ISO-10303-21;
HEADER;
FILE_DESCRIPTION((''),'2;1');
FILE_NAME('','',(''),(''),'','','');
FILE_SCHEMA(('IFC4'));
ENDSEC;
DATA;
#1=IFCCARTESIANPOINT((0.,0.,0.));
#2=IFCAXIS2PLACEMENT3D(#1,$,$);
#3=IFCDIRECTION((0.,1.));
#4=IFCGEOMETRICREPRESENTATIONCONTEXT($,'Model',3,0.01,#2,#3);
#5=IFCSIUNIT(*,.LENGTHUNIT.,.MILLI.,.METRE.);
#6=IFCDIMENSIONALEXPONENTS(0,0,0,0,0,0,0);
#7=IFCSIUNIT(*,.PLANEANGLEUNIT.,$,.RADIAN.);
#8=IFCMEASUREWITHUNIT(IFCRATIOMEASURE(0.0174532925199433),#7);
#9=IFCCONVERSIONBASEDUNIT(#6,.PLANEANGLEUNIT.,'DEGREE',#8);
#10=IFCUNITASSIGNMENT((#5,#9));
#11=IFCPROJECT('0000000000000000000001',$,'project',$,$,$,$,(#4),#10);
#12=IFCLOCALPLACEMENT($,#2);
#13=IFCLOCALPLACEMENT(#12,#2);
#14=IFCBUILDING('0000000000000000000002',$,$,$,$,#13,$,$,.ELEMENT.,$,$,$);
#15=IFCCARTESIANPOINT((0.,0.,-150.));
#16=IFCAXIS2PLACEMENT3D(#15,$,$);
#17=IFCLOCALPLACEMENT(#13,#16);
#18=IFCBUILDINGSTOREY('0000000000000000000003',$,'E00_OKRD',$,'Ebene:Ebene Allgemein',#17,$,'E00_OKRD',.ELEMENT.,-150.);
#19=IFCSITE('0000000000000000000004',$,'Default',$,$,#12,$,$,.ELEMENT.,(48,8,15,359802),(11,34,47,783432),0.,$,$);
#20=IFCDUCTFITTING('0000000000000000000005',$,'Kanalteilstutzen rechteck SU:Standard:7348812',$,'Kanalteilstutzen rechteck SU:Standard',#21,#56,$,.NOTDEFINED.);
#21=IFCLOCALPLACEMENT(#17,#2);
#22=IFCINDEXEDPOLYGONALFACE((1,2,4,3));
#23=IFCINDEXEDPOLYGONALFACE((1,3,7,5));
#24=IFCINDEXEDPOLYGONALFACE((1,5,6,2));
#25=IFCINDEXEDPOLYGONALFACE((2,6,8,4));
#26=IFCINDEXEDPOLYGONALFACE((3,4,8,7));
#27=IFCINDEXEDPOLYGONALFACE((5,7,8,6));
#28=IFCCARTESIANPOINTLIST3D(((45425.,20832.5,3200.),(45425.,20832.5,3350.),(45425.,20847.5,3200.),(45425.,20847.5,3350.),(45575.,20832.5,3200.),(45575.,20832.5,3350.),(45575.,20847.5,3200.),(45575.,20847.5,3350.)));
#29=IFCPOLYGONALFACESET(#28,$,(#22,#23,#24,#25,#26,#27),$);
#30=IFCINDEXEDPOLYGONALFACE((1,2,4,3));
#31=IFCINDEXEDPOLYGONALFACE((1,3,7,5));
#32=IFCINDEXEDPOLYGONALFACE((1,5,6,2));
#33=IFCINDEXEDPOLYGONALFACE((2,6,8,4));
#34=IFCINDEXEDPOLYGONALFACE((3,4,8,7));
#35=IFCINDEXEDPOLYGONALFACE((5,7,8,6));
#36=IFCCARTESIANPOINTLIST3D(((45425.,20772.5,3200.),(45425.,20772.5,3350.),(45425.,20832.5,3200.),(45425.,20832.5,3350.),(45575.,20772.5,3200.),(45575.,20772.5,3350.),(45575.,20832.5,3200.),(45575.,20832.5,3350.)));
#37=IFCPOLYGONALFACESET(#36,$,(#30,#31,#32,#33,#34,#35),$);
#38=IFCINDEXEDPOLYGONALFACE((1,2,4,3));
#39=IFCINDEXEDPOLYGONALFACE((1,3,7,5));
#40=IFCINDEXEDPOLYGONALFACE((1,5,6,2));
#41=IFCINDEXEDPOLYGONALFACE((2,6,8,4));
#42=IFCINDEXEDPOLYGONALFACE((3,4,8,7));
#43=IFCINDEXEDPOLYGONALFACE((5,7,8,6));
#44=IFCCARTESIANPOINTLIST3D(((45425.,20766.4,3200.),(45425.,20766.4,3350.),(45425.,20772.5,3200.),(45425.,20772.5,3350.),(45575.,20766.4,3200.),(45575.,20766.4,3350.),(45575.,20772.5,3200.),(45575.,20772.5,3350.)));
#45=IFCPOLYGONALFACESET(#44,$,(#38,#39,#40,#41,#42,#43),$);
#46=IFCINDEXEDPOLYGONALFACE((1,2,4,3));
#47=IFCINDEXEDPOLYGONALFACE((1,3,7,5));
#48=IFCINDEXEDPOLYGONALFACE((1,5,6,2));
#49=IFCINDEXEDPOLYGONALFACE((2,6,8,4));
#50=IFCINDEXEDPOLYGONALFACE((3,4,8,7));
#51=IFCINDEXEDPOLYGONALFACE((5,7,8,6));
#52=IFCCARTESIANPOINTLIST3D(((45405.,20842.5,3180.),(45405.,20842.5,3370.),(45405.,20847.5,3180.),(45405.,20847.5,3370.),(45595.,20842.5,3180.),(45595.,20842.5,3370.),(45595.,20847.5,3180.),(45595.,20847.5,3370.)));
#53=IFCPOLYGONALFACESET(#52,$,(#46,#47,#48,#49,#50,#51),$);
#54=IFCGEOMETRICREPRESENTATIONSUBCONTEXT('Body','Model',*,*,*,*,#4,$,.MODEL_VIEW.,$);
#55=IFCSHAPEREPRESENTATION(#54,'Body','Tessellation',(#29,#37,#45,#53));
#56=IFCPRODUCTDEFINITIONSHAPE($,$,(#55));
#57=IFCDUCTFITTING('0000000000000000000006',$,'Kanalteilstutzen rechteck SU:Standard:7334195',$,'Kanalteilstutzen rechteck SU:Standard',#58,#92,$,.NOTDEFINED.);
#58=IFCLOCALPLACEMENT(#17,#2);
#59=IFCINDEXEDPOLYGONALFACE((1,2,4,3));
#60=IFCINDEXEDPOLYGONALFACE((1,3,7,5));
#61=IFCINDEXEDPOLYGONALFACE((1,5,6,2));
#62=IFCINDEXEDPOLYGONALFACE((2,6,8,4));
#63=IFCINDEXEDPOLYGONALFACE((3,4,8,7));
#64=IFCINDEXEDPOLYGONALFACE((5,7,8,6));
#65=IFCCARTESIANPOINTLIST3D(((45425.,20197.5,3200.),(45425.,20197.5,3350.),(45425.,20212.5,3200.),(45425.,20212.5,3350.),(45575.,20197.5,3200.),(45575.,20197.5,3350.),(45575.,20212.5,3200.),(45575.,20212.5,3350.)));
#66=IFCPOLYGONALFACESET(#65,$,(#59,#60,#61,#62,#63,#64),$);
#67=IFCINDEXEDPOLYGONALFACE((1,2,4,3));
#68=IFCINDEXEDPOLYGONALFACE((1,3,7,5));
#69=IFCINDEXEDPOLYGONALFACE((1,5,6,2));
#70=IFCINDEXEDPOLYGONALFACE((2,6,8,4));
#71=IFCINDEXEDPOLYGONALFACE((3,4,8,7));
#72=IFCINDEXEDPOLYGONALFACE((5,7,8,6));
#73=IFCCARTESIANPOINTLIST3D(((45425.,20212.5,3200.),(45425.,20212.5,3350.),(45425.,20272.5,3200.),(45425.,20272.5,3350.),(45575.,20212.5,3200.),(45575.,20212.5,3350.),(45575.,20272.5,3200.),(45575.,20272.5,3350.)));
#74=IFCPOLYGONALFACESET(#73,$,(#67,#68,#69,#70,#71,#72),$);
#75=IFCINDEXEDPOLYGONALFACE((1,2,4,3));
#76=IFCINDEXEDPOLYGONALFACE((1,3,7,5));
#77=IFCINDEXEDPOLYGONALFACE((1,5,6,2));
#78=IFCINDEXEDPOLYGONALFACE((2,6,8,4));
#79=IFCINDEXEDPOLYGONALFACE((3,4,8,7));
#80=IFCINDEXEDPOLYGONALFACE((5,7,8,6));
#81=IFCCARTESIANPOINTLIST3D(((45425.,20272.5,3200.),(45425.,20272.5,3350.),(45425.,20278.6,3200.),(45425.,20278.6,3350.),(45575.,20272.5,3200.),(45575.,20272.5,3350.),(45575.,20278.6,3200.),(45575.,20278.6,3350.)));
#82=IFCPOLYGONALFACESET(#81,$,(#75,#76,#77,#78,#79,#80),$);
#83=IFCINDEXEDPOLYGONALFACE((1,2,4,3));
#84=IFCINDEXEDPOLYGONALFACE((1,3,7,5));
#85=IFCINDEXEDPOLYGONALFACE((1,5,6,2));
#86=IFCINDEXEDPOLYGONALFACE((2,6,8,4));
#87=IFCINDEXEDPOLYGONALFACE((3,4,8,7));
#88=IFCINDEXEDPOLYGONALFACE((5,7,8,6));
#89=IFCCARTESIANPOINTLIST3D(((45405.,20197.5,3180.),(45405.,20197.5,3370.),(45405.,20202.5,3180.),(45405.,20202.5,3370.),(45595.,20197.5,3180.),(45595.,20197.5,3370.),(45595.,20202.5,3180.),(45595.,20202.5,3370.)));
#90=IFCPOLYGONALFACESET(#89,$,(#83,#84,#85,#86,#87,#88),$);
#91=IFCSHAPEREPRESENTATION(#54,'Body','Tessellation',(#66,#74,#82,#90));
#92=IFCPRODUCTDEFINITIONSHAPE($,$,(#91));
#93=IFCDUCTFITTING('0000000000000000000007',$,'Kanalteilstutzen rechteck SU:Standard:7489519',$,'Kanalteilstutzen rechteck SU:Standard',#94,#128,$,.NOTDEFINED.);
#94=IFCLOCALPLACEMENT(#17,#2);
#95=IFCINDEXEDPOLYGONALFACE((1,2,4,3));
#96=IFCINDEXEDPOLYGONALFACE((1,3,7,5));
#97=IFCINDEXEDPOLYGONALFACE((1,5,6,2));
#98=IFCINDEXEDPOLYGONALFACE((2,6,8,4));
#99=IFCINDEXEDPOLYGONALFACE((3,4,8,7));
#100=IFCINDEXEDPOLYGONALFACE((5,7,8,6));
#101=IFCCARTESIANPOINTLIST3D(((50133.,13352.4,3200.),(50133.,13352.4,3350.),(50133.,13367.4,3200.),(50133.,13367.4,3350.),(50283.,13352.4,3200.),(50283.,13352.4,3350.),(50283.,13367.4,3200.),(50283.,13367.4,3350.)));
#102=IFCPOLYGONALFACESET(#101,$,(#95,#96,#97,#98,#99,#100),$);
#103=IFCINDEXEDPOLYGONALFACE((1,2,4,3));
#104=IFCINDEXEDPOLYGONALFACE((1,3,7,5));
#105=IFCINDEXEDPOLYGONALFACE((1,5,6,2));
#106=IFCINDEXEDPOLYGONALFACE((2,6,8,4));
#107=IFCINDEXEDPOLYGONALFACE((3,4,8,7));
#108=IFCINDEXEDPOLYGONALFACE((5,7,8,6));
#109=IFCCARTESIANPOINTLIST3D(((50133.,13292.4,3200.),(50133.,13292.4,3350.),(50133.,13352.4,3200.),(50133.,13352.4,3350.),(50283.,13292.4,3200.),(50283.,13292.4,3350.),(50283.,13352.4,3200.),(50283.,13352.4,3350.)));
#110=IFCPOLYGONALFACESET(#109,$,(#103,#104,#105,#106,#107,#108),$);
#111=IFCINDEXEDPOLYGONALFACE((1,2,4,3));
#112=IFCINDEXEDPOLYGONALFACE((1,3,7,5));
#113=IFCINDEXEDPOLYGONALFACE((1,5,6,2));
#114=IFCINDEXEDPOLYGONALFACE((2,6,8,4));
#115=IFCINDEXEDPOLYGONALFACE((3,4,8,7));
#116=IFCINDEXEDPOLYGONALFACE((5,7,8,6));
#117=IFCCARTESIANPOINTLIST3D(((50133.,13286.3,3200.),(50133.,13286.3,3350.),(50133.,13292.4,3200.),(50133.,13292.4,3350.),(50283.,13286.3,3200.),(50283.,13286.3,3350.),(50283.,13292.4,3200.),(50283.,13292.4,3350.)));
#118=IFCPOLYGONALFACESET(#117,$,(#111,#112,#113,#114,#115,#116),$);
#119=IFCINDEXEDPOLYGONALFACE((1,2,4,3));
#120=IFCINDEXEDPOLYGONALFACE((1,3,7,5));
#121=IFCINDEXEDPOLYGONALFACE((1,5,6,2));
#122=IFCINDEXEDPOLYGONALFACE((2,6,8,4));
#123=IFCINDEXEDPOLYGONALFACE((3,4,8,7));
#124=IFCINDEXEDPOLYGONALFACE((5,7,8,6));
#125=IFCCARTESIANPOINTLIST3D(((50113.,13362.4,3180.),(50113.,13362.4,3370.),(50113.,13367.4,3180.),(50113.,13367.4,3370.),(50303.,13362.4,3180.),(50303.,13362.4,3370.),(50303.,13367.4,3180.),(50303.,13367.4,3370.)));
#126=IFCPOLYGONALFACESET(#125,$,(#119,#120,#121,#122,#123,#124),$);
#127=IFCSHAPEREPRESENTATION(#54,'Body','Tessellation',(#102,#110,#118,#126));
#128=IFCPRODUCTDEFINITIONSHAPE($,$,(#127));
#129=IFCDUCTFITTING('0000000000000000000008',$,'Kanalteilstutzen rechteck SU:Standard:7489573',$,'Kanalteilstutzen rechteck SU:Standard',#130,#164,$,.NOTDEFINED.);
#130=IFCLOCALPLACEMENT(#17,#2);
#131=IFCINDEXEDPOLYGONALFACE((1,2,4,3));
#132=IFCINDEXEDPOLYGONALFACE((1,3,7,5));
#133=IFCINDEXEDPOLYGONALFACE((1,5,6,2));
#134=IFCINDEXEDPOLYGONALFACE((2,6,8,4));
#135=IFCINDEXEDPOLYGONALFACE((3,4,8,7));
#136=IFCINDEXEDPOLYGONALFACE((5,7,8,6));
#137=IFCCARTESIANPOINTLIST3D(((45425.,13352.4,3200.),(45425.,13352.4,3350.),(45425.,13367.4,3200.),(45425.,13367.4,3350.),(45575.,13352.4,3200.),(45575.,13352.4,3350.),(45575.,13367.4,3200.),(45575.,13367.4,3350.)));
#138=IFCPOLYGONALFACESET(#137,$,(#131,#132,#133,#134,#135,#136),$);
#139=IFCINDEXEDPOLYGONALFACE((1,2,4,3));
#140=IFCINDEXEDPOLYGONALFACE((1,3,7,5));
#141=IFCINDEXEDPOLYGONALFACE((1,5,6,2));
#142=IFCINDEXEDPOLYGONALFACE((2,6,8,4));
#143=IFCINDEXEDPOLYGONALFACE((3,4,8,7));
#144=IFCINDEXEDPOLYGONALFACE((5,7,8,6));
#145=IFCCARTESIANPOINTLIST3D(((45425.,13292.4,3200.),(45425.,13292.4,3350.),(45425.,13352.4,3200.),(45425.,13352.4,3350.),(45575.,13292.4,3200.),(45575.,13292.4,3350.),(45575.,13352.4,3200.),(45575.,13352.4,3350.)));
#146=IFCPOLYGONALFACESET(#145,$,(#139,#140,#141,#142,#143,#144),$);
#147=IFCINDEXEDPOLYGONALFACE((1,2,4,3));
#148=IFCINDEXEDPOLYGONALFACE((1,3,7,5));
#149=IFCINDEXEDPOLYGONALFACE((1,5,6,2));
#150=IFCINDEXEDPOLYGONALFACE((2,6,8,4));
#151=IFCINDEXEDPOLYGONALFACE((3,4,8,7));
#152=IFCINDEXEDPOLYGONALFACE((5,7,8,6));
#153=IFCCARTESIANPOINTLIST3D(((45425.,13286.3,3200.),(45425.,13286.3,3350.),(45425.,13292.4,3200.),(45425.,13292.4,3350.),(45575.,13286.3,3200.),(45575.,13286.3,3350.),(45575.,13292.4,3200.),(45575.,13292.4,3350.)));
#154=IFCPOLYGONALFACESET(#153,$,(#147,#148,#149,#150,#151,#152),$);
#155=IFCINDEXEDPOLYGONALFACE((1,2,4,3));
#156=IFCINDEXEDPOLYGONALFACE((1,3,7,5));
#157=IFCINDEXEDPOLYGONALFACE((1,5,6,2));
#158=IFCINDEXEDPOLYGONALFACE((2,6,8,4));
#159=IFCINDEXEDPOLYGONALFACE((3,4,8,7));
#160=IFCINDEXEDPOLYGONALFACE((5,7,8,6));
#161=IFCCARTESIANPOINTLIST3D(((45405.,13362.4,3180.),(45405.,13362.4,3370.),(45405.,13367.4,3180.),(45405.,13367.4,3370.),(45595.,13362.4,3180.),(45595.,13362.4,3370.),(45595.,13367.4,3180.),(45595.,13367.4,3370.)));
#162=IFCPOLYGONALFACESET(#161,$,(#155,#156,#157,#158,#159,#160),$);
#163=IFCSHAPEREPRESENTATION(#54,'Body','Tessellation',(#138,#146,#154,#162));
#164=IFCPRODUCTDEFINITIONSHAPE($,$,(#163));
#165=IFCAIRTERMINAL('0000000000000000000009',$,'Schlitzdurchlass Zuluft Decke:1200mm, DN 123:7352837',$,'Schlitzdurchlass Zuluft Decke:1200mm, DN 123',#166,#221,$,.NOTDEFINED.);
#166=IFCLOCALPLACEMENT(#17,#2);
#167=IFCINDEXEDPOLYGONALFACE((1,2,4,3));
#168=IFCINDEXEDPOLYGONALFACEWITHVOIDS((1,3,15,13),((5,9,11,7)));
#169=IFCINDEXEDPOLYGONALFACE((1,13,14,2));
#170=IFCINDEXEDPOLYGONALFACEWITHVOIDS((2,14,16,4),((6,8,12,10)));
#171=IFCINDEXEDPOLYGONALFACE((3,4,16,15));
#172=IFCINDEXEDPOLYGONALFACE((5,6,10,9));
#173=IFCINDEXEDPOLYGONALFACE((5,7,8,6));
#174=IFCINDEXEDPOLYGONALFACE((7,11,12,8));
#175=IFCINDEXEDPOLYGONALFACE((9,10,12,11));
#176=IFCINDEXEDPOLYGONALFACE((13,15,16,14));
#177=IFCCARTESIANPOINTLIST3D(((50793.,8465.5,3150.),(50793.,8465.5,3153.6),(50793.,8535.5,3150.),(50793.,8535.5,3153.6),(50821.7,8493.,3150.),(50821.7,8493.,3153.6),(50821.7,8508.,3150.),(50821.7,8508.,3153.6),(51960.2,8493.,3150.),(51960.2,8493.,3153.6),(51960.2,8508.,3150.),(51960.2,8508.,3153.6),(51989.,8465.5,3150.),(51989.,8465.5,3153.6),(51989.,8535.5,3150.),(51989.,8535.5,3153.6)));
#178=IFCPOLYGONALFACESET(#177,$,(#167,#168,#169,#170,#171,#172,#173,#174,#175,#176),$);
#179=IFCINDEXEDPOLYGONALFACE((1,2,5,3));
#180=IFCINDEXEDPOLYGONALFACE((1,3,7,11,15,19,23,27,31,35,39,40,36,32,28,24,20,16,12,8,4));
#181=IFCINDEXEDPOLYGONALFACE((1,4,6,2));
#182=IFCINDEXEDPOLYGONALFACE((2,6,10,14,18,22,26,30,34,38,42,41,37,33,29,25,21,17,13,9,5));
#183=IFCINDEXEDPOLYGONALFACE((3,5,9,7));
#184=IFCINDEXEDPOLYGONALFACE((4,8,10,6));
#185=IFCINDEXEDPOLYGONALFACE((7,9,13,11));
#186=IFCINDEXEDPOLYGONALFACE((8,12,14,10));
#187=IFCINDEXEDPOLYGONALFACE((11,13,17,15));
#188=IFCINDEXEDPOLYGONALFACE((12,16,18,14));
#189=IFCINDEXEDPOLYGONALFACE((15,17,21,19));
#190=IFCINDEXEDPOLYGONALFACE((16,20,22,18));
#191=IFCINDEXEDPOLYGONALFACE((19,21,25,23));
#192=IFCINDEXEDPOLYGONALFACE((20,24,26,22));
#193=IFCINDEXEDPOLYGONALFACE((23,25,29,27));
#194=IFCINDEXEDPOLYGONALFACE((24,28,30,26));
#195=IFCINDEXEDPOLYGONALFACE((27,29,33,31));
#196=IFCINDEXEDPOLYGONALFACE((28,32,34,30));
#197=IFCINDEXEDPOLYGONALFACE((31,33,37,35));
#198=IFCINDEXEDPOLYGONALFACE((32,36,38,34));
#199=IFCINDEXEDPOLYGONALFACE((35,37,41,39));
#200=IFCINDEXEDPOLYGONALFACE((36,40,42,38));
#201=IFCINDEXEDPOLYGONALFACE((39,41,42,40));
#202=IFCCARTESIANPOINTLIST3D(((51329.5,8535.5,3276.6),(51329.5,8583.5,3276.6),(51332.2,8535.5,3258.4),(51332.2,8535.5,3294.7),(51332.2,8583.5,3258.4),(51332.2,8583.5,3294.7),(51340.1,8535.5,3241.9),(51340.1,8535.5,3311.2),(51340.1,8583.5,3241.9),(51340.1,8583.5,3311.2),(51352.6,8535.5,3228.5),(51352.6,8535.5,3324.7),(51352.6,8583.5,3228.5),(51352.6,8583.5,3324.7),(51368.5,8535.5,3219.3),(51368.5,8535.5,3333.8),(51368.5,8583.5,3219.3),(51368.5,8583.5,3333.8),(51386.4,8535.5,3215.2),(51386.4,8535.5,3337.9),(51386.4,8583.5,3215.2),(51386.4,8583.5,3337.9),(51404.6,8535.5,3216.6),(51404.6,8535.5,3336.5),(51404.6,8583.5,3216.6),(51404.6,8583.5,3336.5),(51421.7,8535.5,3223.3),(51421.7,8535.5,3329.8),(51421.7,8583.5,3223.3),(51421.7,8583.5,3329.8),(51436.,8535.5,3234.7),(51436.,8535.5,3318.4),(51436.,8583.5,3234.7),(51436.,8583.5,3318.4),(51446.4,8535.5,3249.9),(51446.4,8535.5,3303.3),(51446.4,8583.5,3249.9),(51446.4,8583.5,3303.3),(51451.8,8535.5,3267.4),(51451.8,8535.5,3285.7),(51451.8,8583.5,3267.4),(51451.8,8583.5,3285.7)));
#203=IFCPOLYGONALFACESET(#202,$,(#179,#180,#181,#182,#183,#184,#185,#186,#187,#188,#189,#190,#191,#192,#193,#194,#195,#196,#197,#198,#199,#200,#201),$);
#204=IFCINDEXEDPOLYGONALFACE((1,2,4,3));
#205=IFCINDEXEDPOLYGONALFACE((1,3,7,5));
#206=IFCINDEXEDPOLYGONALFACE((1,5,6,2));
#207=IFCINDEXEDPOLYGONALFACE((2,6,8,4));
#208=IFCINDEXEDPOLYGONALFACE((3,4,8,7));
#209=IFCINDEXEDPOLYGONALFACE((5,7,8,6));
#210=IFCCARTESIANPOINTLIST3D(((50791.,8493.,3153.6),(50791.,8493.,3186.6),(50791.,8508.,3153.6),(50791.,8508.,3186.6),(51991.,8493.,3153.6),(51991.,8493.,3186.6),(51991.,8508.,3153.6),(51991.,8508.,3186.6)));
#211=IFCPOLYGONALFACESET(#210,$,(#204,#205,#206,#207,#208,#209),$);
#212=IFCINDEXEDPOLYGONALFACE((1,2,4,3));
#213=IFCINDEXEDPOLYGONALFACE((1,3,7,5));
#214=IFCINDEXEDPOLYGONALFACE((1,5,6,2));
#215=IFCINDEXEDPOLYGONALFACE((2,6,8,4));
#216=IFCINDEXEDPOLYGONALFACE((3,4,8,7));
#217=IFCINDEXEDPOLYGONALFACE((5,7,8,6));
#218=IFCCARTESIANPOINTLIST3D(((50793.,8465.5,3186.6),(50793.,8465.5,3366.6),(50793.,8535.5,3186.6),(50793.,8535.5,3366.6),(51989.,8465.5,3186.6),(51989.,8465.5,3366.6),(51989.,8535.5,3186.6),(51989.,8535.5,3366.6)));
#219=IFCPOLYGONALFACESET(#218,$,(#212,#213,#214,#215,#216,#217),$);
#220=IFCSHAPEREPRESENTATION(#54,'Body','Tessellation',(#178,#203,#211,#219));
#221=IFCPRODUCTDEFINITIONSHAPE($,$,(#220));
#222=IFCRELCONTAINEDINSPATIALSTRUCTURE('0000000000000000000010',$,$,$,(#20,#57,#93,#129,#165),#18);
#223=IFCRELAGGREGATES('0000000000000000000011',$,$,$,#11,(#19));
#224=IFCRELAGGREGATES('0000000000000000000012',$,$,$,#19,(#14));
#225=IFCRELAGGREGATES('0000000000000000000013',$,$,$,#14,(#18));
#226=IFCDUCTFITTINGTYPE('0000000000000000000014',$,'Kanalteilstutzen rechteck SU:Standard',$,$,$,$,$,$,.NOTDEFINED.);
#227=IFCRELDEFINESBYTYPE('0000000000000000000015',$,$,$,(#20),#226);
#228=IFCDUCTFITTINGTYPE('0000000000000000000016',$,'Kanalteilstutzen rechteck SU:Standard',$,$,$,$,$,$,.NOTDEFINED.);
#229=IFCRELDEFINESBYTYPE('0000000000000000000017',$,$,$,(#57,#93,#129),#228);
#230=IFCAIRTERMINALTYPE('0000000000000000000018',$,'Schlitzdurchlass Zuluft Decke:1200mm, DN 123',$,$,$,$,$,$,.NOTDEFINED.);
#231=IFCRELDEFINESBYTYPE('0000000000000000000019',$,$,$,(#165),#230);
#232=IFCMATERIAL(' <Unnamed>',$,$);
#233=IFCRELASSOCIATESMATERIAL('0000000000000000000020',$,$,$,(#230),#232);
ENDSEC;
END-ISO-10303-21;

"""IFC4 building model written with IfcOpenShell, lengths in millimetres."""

from ifc_helpers import new_model, entity, si_unit, converted_unit, direction, frame, frame_2d, origin, origin_2d_with_axis, place, context, subcontext, project, spatial, polyline, rectangle, circle, outline, extrude, source, transform, mapped, material, type_object, type_shapes, element, save


model = new_model("IFC4")

# Units and contexts
model_context = context("Model", 3, precision=0.01, world=origin(), true_north=direction((0.0, 1.0)))
body_context = subcontext(model_context, "Body", "Model", "MODEL_VIEW")
ifc_project = project(units=[si_unit("LENGTHUNIT", "METRE", prefix="MILLI"), converted_unit("PLANEANGLEUNIT", "DEGREE", entity("IfcRatioMeasure", 0.0174532925199433), si_unit("PLANEANGLEUNIT", "RADIAN"), dimensions=[0, 0, 0, 0, 0, 0, 0])], contexts=[model_context])

# Site, building, storey
site_placement = place(None, origin())
site = spatial("IfcSite", under=ifc_project, at=site_placement, Name="Default", CompositionType="ELEMENT", RefLatitude=(48, 8, 15, 359802), RefLongitude=(11, 34, 47, 783432), RefElevation=0.0)
building_placement = place(site_placement, origin())
building = spatial("IfcBuilding", under=site, at=building_placement, CompositionType="ELEMENT")
storey_placement = place(building_placement, frame((0.0, 0.0, -150.0)))
storey = spatial("IfcBuildingStorey", under=building, at=storey_placement, Name="E00_OKRD", ObjectType="Ebene:Ebene Allgemein", LongName="E00_OKRD", CompositionType="ELEMENT", Elevation=-150.0)

# Shared definitions
ifc_material_1 = material(Name=" <Unnamed>")

# Duct fittings
duct_fitting_type_1 = type_object("IfcDuctFittingType", Name="Kanalteilstutzen rechteck SU:Standard", PredefinedType="NOTDEFINED")
shared_shape_1 = source(origin(), body_context, "Body", "SweptSolid", [
    extrude(rectangle(XDim=150.0, YDim=15.0, at=origin_2d_with_axis()), frame((67.5, 0.0, -75.0), z_axis=(0.0, 0.0, 1.0), x_axis=(0.0, -1.0, 0.0)), (0.0, 0.0, 1.0), 150.0),
    extrude(rectangle(XDim=150.0, YDim=60.0, at=frame_2d((0.0, 0.0), x_axis=(1.0, 0.0))), frame((30.0, 0.0, -75.0), z_axis=(0.0, 0.0, 1.0), x_axis=(0.0, -1.0, 0.0)), (0.0, 0.0, 1.0), 150.0),
    extrude(rectangle(XDim=150.0, YDim=6.1, at=frame_2d((0.0, 0.0), x_axis=(1.0, 0.0))), frame((-3.0, 0.0, -75.0), z_axis=(0.0, 0.0, 1.0), x_axis=(0.0, -1.0, 0.0)), (0.0, 0.0, 1.0), 150.0),
    extrude(rectangle(XDim=190.0, YDim=5.0, at=origin_2d_with_axis()), frame((72.5, 0.0, -95.0), z_axis=(0.0, 0.0, 1.0), x_axis=(0.0, -1.0, 0.0)), (0.0, 0.0, 1.0), 190.0),
])
type_shapes(duct_fitting_type_1, [shared_shape_1])
duct_fitting_1_placement = place(storey_placement, frame((45500.0, 20772.5, 3275.0), z_axis=(0.0, 0.0, -1.0), x_axis=(0.0, 1.0, 0.0)))
element("IfcDuctFitting", 1, at=duct_fitting_1_placement, inside=storey, type_object=duct_fitting_type_1, Name="Kanalteilstutzen rechteck SU:Standard:7348812", ObjectType="Kanalteilstutzen rechteck SU:Standard", PredefinedType="NOTDEFINED", context=body_context, shape_type="MappedRepresentation", body=[
    mapped(shared_shape_1, transform((0.0, 0.0, 0.0), scale=1.0)),
])
duct_fitting_type_2 = type_object("IfcDuctFittingType", Name="Kanalteilstutzen rechteck SU:Standard", PredefinedType="NOTDEFINED")
shared_shape_2 = source(origin(), body_context, "Body", "SweptSolid", [
    extrude(rectangle(XDim=15.0, YDim=150.0, at=frame_2d((0.0, 0.0), x_axis=(1.0, 0.0))), frame((67.5, 0.0, -75.0)), (0.0, 0.0, 1.0), 150.0),
    extrude(rectangle(XDim=60.0, YDim=150.0, at=frame_2d((0.0, 0.0), x_axis=(1.0, 0.0))), frame((30.0, 0.0, -75.0)), (0.0, 0.0, 1.0), 150.0),
    extrude(rectangle(XDim=6.1, YDim=150.0, at=frame_2d((0.0, 0.0), x_axis=(1.0, 0.0))), frame((-3.0, 0.0, -75.0)), (0.0, 0.0, 1.0), 150.0),
    extrude(rectangle(XDim=5.0, YDim=190.0, at=origin_2d_with_axis()), frame((72.5, 0.0, -95.0)), (0.0, 0.0, 1.0), 190.0),
])
type_shapes(duct_fitting_type_2, [shared_shape_2])
for number, where, z_axis, x_axis, name in (
    (2, (45500.0, 20272.5, 3275.0), (0.0, 0.0, -1.0), (0.0, -1.0, 0.0), "Kanalteilstutzen rechteck SU:Standard:7334195"),
    (3, (50208.0, 13292.4, 3275.0), (0.0, 0.0, 1.0), (0.0, 1.0, 0.0), "Kanalteilstutzen rechteck SU:Standard:7489519"),
    (4, (45500.0, 13292.4, 3275.0), (0.0, 0.0, 1.0), (0.0, 1.0, 0.0), "Kanalteilstutzen rechteck SU:Standard:7489573"),
):
    element("IfcDuctFitting", number, at=place(storey_placement, frame(where, z_axis=z_axis, x_axis=x_axis)), inside=storey, type_object=duct_fitting_type_2, Name=name, ObjectType="Kanalteilstutzen rechteck SU:Standard", PredefinedType="NOTDEFINED", context=body_context, shape_type="MappedRepresentation", body=[
        mapped(shared_shape_2, transform((0.0, 0.0, 0.0), scale=1.0)),
    ])

# Air terminal
air_terminal_type_1 = type_object("IfcAirTerminalType", Name="Schlitzdurchlass Zuluft Decke:1200mm, DN 123", PredefinedType="NOTDEFINED", material=ifc_material_1)
shared_shape_3 = source(origin(), body_context, "Body", "SweptSolid", [
    extrude(outline(polyline([(-598.0, -35.0), (598.0, -35.0), (598.0, 35.0), (-598.0, 35.0), (-598.0, -35.0)]), holes=[polyline([(-569.2, -7.5), (-569.2, 7.5), (569.2, 7.5), (569.2, -7.5), (-569.2, -7.5)])]), frame((600.0, 35.0, 0.0), z_axis=(0.0, 0.0, 1.0), x_axis=(-1.0, 0.0, 0.0)), (0.0, 0.0, 1.0), 3.6),
    extrude(circle(Radius=61.5, at=frame_2d((0.0, 0.0), x_axis=(1.0, 0.0))), frame((600.0, 70.0, 126.6), z_axis=(0.0, 1.0, 0.0), x_axis=(-1.0, 0.0, 0.0)), (0.0, 0.0, 1.0), 48.0),
    extrude(rectangle(XDim=1200.0, YDim=15.0, at=origin_2d_with_axis()), frame((600.0, 35.0, 3.6), z_axis=(0.0, 0.0, 1.0), x_axis=(-1.0, 0.0, 0.0)), (0.0, 0.0, 1.0), 33.0),
    extrude(rectangle(XDim=1196.0, YDim=70.0, at=origin_2d_with_axis()), frame((600.0, 35.0, 36.6), z_axis=(0.0, 0.0, 1.0), x_axis=(-1.0, 0.0, 0.0)), (0.0, 0.0, 1.0), 180.0),
])
type_shapes(air_terminal_type_1, [shared_shape_3])
air_terminal_1_placement = place(storey_placement, frame((50791.0, 8465.5, 3150.0)))
element("IfcAirTerminal", 5, at=air_terminal_1_placement, inside=storey, type_object=air_terminal_type_1, Name="Schlitzdurchlass Zuluft Decke:1200mm, DN 123:7352837", ObjectType="Schlitzdurchlass Zuluft Decke:1200mm, DN 123", PredefinedType="NOTDEFINED", context=body_context, shape_type="MappedRepresentation", body=[
    mapped(shared_shape_3, transform((0.0, 0.0, 0.0), scale=1.0)),
])

save(model, "model.ifc")
